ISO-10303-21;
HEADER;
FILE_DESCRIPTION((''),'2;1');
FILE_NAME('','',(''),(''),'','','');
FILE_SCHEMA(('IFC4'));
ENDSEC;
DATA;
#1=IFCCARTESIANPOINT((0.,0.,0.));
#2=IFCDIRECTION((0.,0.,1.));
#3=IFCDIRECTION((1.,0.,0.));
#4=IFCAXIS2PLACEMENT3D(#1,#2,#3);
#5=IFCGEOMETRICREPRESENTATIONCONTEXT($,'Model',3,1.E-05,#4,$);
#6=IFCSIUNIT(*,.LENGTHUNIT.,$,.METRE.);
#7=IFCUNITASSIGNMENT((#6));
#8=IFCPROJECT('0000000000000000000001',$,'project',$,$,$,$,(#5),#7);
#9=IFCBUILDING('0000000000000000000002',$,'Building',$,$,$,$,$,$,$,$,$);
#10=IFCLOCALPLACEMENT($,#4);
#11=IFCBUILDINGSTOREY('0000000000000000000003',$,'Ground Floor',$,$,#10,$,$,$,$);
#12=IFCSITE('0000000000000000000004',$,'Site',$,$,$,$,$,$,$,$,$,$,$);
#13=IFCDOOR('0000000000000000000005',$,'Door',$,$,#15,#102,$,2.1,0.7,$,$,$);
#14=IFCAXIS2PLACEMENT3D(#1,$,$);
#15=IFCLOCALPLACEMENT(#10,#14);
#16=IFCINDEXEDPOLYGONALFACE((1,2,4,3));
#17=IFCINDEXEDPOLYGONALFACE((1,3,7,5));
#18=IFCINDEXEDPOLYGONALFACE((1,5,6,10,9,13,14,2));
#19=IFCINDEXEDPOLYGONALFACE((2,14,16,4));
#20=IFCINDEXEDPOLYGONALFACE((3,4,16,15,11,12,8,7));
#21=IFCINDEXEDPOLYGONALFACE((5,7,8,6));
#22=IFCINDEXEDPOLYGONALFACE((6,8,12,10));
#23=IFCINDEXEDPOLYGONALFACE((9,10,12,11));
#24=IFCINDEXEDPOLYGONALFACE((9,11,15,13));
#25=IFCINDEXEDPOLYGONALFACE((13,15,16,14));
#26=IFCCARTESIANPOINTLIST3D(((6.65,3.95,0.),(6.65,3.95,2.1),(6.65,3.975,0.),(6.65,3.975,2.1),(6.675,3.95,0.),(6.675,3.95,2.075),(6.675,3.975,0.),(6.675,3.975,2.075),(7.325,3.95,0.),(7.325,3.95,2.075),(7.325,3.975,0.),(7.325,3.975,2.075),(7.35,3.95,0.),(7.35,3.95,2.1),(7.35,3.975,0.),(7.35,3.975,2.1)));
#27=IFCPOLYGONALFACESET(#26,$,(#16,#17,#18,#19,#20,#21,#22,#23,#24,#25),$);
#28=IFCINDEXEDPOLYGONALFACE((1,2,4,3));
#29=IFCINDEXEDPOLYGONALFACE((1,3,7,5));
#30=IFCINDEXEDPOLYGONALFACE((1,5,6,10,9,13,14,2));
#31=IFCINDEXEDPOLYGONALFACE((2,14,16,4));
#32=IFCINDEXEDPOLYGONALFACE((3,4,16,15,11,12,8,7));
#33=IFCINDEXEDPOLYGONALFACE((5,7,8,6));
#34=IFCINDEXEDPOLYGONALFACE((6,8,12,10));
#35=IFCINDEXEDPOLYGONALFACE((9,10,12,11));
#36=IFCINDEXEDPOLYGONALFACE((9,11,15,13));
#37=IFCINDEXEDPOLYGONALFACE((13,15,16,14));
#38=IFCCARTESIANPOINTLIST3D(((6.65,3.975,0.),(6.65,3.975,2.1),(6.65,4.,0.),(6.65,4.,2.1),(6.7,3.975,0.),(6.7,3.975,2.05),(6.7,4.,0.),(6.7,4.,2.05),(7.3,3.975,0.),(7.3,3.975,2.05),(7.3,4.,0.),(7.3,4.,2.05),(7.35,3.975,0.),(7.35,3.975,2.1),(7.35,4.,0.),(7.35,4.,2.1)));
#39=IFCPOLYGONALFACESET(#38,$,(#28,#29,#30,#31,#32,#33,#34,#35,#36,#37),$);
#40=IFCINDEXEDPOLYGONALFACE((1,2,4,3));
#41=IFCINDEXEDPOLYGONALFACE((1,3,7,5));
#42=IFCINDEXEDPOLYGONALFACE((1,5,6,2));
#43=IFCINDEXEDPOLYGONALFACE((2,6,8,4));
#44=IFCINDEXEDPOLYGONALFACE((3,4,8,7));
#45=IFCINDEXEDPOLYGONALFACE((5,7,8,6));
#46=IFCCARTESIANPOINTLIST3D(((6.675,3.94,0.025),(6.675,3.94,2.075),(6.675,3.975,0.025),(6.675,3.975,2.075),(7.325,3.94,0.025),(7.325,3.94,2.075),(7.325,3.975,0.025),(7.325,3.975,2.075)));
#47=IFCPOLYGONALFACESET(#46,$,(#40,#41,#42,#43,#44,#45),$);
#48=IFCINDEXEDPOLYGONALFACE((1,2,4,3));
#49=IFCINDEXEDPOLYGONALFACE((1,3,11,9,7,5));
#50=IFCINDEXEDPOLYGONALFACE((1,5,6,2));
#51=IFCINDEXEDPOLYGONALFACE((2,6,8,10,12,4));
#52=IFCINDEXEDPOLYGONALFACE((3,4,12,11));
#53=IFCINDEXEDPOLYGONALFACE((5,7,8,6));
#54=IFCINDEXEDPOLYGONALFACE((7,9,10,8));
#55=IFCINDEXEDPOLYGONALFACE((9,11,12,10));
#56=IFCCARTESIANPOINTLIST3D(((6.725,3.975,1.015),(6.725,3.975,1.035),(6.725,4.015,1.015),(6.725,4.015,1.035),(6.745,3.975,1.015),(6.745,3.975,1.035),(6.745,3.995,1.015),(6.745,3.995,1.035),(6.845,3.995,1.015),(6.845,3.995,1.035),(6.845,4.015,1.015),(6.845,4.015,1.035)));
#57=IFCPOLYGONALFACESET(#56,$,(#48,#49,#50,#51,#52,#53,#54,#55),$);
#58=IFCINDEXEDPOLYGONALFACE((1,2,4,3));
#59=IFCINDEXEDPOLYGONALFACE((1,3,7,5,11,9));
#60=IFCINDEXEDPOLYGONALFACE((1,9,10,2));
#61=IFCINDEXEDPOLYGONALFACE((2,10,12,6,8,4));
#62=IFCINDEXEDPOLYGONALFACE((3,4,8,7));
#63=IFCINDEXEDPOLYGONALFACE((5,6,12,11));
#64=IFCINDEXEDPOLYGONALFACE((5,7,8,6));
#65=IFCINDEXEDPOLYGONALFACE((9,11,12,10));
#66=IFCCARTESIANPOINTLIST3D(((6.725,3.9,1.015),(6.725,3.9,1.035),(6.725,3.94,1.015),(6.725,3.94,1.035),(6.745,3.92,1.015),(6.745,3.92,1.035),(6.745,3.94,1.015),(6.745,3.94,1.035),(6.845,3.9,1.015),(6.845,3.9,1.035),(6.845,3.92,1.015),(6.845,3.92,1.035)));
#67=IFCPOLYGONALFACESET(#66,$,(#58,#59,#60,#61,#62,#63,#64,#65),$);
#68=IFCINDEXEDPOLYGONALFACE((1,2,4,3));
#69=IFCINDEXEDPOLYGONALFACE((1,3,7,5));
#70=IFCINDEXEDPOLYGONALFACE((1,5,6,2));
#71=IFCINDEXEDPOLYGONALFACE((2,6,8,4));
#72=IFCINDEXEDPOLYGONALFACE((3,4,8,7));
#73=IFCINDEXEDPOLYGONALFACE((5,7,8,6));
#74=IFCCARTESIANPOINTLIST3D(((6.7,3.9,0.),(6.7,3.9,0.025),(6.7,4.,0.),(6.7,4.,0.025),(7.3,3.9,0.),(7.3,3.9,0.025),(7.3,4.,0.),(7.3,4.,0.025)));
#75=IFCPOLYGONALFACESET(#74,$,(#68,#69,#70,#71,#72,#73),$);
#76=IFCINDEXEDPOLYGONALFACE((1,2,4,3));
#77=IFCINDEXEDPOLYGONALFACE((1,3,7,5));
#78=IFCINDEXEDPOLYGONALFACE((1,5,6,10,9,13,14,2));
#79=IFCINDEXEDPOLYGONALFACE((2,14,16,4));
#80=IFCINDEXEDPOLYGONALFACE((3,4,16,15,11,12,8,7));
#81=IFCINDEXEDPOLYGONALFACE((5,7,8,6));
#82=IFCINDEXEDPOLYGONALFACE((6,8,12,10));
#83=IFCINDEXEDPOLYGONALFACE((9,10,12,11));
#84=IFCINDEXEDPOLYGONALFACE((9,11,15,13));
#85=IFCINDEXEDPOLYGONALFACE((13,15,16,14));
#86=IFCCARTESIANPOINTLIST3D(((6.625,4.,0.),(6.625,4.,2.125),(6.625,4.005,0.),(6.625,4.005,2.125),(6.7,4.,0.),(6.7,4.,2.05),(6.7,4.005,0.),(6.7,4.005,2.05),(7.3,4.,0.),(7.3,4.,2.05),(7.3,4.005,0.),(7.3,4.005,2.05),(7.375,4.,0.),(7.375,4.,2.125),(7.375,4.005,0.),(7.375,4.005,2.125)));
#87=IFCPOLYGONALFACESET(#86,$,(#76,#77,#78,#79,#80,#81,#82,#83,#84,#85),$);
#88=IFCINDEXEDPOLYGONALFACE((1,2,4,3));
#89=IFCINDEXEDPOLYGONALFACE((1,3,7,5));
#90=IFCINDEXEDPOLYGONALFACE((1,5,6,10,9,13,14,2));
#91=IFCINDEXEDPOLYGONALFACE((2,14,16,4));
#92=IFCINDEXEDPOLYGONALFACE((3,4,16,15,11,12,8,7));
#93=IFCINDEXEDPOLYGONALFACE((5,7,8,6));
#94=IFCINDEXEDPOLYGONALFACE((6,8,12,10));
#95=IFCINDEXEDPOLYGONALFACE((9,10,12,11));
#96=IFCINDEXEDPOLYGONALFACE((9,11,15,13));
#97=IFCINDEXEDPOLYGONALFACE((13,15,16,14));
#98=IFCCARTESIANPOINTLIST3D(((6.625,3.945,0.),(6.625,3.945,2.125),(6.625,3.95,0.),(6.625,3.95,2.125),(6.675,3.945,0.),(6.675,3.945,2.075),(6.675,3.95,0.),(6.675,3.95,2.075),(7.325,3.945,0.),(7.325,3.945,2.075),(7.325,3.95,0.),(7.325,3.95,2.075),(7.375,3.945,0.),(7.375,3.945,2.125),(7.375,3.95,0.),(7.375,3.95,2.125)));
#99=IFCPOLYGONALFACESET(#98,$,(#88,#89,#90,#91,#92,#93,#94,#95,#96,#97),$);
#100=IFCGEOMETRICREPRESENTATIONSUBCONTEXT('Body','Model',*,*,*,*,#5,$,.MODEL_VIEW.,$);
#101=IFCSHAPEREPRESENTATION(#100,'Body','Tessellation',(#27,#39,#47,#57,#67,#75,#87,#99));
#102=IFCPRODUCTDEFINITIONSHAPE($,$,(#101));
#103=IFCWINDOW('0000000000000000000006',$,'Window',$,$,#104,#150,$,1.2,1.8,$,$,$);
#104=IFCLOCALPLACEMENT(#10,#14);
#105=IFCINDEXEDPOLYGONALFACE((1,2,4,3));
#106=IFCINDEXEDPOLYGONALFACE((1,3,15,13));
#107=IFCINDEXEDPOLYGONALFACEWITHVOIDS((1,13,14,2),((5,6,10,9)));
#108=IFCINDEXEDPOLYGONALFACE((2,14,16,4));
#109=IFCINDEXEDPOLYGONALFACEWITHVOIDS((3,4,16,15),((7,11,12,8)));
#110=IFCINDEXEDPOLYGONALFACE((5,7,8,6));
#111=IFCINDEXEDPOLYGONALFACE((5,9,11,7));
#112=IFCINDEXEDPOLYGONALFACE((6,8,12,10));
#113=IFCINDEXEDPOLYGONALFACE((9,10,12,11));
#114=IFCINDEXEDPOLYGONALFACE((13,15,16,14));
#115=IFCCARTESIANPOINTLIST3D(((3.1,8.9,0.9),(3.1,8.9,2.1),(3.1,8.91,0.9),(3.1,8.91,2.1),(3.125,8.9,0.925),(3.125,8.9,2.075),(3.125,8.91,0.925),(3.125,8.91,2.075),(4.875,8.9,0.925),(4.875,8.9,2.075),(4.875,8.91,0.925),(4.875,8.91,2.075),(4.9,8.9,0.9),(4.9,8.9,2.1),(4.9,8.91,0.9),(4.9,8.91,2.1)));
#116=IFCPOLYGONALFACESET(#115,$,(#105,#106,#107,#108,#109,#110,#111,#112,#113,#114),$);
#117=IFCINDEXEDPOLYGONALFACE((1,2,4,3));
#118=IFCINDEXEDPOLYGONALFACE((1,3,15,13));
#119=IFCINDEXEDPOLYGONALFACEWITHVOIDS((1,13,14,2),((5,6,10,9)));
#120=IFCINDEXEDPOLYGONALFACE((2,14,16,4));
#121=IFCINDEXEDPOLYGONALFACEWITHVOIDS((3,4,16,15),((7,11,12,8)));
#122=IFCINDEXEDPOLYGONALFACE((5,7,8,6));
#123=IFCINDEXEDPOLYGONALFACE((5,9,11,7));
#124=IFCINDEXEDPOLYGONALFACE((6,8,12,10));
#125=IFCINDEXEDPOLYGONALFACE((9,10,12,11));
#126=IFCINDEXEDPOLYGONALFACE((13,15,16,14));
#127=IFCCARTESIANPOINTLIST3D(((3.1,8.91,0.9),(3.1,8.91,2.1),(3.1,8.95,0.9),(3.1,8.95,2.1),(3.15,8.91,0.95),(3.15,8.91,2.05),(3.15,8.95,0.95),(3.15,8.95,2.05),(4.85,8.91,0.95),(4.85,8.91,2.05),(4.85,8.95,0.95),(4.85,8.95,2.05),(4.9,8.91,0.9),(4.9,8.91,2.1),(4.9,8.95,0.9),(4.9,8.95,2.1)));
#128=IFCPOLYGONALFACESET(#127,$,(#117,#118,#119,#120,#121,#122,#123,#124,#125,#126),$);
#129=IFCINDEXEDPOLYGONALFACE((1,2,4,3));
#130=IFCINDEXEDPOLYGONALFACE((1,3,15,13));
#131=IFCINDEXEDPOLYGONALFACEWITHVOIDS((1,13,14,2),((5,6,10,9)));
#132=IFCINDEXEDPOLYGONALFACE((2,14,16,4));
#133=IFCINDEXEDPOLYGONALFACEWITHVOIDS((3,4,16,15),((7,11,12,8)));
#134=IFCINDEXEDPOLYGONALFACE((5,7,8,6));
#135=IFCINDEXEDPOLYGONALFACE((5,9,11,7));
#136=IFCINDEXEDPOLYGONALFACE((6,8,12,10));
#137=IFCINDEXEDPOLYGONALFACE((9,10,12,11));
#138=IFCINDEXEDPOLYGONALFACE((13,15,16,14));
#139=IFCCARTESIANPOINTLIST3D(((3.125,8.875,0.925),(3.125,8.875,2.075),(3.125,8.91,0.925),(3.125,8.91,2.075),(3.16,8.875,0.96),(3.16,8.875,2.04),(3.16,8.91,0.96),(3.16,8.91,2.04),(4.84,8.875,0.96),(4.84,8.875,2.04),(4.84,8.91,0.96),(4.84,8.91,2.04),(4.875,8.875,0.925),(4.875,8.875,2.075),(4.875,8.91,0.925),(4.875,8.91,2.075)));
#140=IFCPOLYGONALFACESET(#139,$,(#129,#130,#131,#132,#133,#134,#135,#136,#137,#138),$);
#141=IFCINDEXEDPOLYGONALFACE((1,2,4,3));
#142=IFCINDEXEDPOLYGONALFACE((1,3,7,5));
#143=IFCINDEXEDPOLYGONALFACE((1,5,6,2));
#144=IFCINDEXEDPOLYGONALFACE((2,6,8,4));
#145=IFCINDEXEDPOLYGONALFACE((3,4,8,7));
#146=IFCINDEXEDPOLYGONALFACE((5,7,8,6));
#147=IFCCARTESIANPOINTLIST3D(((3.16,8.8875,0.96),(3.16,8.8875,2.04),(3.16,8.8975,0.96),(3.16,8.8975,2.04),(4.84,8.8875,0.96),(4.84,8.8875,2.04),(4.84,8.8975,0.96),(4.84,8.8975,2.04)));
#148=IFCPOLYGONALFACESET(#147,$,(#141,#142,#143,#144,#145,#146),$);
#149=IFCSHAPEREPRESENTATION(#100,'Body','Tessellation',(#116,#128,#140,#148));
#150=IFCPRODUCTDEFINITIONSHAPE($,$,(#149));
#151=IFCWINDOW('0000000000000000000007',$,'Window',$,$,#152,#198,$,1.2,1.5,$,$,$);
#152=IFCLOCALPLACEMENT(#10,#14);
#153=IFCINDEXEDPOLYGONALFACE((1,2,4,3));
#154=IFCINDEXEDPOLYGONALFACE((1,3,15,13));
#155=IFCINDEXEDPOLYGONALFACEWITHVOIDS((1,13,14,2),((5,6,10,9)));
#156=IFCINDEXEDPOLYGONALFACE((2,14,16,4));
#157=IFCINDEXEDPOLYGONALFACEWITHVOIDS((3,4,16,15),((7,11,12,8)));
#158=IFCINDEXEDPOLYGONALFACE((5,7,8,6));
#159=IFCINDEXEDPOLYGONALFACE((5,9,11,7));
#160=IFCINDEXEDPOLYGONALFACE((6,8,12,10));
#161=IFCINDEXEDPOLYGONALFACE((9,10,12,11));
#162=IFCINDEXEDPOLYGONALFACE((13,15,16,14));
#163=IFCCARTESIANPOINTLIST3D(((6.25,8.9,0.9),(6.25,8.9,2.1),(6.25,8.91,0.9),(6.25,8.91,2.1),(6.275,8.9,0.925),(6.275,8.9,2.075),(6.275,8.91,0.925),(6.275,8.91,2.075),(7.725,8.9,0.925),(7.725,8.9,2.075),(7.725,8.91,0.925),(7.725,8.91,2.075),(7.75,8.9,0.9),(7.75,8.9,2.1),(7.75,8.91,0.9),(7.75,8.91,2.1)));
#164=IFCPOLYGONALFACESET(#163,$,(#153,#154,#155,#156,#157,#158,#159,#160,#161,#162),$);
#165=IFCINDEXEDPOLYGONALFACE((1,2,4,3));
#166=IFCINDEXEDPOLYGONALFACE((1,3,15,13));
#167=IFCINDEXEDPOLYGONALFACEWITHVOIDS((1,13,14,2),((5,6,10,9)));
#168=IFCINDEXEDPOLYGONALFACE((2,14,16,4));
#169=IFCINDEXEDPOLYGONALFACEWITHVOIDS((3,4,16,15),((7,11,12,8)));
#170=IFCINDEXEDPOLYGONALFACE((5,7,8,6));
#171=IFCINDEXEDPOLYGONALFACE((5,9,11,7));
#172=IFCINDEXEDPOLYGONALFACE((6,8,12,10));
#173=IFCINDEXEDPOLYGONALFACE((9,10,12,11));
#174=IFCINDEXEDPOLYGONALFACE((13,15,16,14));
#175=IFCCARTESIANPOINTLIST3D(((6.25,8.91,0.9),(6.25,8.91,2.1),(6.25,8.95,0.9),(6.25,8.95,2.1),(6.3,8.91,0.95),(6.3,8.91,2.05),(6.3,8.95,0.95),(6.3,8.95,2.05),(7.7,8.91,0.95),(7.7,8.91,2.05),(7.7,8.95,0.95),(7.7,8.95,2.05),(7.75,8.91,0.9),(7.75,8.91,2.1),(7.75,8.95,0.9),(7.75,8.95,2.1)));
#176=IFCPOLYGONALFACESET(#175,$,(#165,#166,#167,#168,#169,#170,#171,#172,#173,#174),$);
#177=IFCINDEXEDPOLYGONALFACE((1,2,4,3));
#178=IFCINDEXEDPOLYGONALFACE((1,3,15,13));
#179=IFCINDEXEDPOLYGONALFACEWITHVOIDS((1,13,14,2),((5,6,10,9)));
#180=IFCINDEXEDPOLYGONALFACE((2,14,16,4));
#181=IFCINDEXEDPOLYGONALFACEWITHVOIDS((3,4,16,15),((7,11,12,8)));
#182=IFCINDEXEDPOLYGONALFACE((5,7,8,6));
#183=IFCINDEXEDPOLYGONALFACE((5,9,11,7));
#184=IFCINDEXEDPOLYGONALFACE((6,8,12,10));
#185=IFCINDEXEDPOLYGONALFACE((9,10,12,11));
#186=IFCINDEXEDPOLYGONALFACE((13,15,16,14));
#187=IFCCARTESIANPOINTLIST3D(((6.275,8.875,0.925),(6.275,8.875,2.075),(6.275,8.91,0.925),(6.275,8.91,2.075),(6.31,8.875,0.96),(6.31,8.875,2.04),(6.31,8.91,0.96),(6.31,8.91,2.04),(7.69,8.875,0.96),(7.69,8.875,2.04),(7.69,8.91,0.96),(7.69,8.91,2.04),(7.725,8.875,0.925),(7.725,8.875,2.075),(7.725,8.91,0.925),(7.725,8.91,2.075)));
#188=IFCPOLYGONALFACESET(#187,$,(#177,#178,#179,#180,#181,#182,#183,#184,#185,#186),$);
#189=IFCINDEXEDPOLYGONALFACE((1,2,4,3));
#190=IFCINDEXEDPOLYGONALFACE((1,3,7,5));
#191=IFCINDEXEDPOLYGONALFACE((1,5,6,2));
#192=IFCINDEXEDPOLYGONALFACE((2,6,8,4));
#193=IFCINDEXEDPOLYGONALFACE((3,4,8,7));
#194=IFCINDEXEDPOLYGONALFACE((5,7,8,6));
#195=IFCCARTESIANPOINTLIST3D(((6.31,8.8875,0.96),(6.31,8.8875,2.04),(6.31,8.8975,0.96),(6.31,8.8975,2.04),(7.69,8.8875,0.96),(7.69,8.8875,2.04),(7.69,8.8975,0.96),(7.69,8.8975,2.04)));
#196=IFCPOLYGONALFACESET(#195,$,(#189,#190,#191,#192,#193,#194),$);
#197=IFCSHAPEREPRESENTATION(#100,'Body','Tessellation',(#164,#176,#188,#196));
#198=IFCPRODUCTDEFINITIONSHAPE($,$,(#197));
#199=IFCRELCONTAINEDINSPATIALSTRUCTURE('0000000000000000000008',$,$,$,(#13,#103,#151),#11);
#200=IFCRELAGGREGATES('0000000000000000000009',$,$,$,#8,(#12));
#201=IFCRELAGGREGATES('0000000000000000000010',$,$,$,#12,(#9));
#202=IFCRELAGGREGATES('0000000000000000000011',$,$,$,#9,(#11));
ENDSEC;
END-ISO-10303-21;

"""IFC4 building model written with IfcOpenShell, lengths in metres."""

from ifc_helpers import new_model, si_unit, frame, origin_with_axes, place, context, subcontext, project, spatial, line, indexed_curve, outline, extrude, element, save


model = new_model("IFC4")

# Units and contexts
model_context = context("Model", 3, precision=1e-05, world=origin_with_axes())
body_context = subcontext(model_context, "Body", "Model", "MODEL_VIEW")
ifc_project = project(units=[si_unit("LENGTHUNIT", "METRE")], contexts=[model_context])

# Site, building, storey
site = spatial("IfcSite", under=ifc_project, Name="Site")
building = spatial("IfcBuilding", under=site, Name="Building")
storey_placement = place(None, origin_with_axes())
storey = spatial("IfcBuildingStorey", under=building, at=storey_placement, Name="Ground Floor")

# Door
door_1_placement = place(storey_placement, frame((7.35, 4.0, 0.0), z_axis=(0.0, 0.0, 1.0), x_axis=(-1.0, 0.0, 0.0)))
element("IfcDoor", 1, at=door_1_placement, inside=storey, Name="Door", OverallHeight=2.1, OverallWidth=0.7, context=body_context, shape_type="SweptSolid", body=[
    extrude(outline(indexed_curve([(0.0, 0.0), (0.0, 2.1), (0.7, 2.1), (0.7, 0.0), (0.675, 0.0), (0.675, 2.075), (0.025, 2.075), (0.025, 0.0)], segments=[line(1, 2, 3, 4, 5, 6, 7, 8, 1)])), frame((0.0, 0.025, 0.0), z_axis=(0.0, -1.0, 0.0), x_axis=(1.0, 0.0, 0.0)), (0.0, 0.0, -1.0), 0.025),
    extrude(outline(indexed_curve([(0.0, 0.0), (0.0, 2.1), (0.7, 2.1), (0.7, 0.0), (0.65, 0.0), (0.65, 2.05), (0.05, 2.05), (0.05, 0.0)], segments=[line(1, 2, 3, 4, 5, 6, 7, 8, 1)])), frame((0.0, 0.0, 0.0), z_axis=(0.0, -1.0, 0.0), x_axis=(1.0, 0.0, 0.0)), (0.0, 0.0, -1.0), 0.025),
    extrude(outline(indexed_curve([(0.0, 0.0), (0.65, 0.0), (0.65, 0.035), (0.0, 0.035)], segments=[line(1, 2, 3, 4, 1)])), frame((0.025, 0.025, 0.025), z_axis=(0.0, 0.0, 1.0), x_axis=(1.0, 0.0, 0.0)), (0.0, 0.0, 1.0), 2.05),
    extrude(outline(indexed_curve([(0.0, 0.0), (0.0, -0.04), (-0.12, -0.04), (-0.12, -0.02), (-0.02, -0.02), (-0.02, 0.0)], segments=[line(1, 2, 3, 4, 5, 6, 1)])), frame((0.625, 0.025, 1.015), z_axis=(0.0, 0.0, 1.0), x_axis=(1.0, 0.0, 0.0)), (0.0, 0.0, 1.0), 0.02),
    extrude(outline(indexed_curve([(0.0, 0.0), (0.0, 0.04), (-0.12, 0.04), (-0.12, 0.02), (-0.02, 0.02), (-0.02, 0.0)], segments=[line(1, 2, 3, 4, 5, 6, 1)])), frame((0.625, 0.06, 1.015), z_axis=(0.0, 0.0, 1.0), x_axis=(1.0, 0.0, 0.0)), (0.0, 0.0, 1.0), 0.02),
    extrude(outline(indexed_curve([(0.0, 0.0), (0.6, 0.0), (0.6, 0.1), (0.0, 0.1)], segments=[line(1, 2, 3, 4, 1)])), frame((0.05, 0.0, 0.0), z_axis=(0.0, 0.0, 1.0), x_axis=(1.0, 0.0, 0.0)), (0.0, 0.0, 1.0), 0.025),
    extrude(outline(indexed_curve([(0.0, 0.0), (0.0, 2.125), (0.75, 2.125), (0.75, 0.0), (0.675, 0.0), (0.675, 2.05), (0.075, 2.05), (0.075, 0.0)], segments=[line(1, 2, 3, 4, 5, 6, 7, 8, 1)])), frame((-0.025, -0.005, 0.0), z_axis=(0.0, -1.0, 0.0), x_axis=(1.0, 0.0, 0.0)), (0.0, 0.0, -1.0), 0.005),
    extrude(outline(indexed_curve([(0.0, 0.0), (0.0, 2.125), (0.75, 2.125), (0.75, 0.0), (0.7, 0.0), (0.7, 2.075), (0.05, 2.075), (0.05, 0.0)], segments=[line(1, 2, 3, 4, 5, 6, 7, 8, 1)])), frame((-0.025, 0.05, 0.0), z_axis=(0.0, -1.0, 0.0), x_axis=(1.0, 0.0, 0.0)), (0.0, 0.0, -1.0), 0.005),
])

# Windows
window_1_placement = place(storey_placement, frame((4.9, 9.0, 0.9), z_axis=(0.0, 0.0, 1.0), x_axis=(-1.0, 0.0, 0.0)))
element("IfcWindow", 2, at=window_1_placement, inside=storey, Name="Window", OverallHeight=1.2, OverallWidth=1.8, context=body_context, shape_type="SweptSolid", body=[
    extrude(outline(indexed_curve([(0.0, 0.0), (1.8, 0.0), (1.8, 1.2), (0.0, 1.2)], segments=[line(1, 2, 3, 4, 1)]), holes=[indexed_curve([(0.025, 0.025), (1.775, 0.025), (1.775, 1.175), (0.025, 1.175)], segments=[line(1, 2, 3, 4, 1)])]), frame((0.0, 0.09, 0.0), z_axis=(0.0, -1.0, 0.0), x_axis=(1.0, 0.0, 0.0)), (0.0, 0.0, -1.0), 0.01),
    extrude(outline(indexed_curve([(0.0, 0.0), (1.8, 0.0), (1.8, 1.2), (0.0, 1.2)], segments=[line(1, 2, 3, 4, 1)]), holes=[indexed_curve([(0.05, 0.05), (1.75, 0.05), (1.75, 1.15), (0.05, 1.15)], segments=[line(1, 2, 3, 4, 1)])]), frame((0.0, 0.05, 0.0), z_axis=(0.0, -1.0, 0.0), x_axis=(1.0, 0.0, 0.0)), (0.0, 0.0, -1.0), 0.04),
    extrude(outline(indexed_curve([(0.0, 0.0), (1.75, 0.0), (1.75, 1.15), (0.0, 1.15)], segments=[line(1, 2, 3, 4, 1)]), holes=[indexed_curve([(0.035, 0.035), (1.715, 0.035), (1.715, 1.115), (0.035, 1.115)], segments=[line(1, 2, 3, 4, 1)])]), frame((0.025, 0.09, 0.025), z_axis=(0.0, -1.0, 0.0), x_axis=(1.0, 0.0, 0.0)), (0.0, 0.0, -1.0), 0.035),
    extrude(outline(indexed_curve([(0.035, 0.035), (1.715, 0.035), (1.715, 1.115), (0.035, 1.115)], segments=[line(1, 2, 3, 4, 1)])), frame((0.025, 0.1025, 0.025), z_axis=(0.0, -1.0, 0.0), x_axis=(1.0, 0.0, 0.0)), (0.0, 0.0, -1.0), 0.01),
])
window_2_placement = place(storey_placement, frame((7.75, 9.0, 0.9), z_axis=(0.0, 0.0, 1.0), x_axis=(-1.0, 0.0, 0.0)))
element("IfcWindow", 3, at=window_2_placement, inside=storey, Name="Window", OverallHeight=1.2, OverallWidth=1.5, context=body_context, shape_type="SweptSolid", body=[
    extrude(outline(indexed_curve([(0.0, 0.0), (1.5, 0.0), (1.5, 1.2), (0.0, 1.2)], segments=[line(1, 2, 3, 4, 1)]), holes=[indexed_curve([(0.025, 0.025), (1.475, 0.025), (1.475, 1.175), (0.025, 1.175)], segments=[line(1, 2, 3, 4, 1)])]), frame((0.0, 0.09, 0.0), z_axis=(0.0, -1.0, 0.0), x_axis=(1.0, 0.0, 0.0)), (0.0, 0.0, -1.0), 0.01),
    extrude(outline(indexed_curve([(0.0, 0.0), (1.5, 0.0), (1.5, 1.2), (0.0, 1.2)], segments=[line(1, 2, 3, 4, 1)]), holes=[indexed_curve([(0.05, 0.05), (1.45, 0.05), (1.45, 1.15), (0.05, 1.15)], segments=[line(1, 2, 3, 4, 1)])]), frame((0.0, 0.05, 0.0), z_axis=(0.0, -1.0, 0.0), x_axis=(1.0, 0.0, 0.0)), (0.0, 0.0, -1.0), 0.04),
    extrude(outline(indexed_curve([(0.0, 0.0), (1.45, 0.0), (1.45, 1.15), (0.0, 1.15)], segments=[line(1, 2, 3, 4, 1)]), holes=[indexed_curve([(0.035, 0.035), (1.415, 0.035), (1.415, 1.115), (0.035, 1.115)], segments=[line(1, 2, 3, 4, 1)])]), frame((0.025, 0.09, 0.025), z_axis=(0.0, -1.0, 0.0), x_axis=(1.0, 0.0, 0.0)), (0.0, 0.0, -1.0), 0.035),
    extrude(outline(indexed_curve([(0.035, 0.035), (1.415, 0.035), (1.415, 1.115), (0.035, 1.115)], segments=[line(1, 2, 3, 4, 1)])), frame((0.025, 0.1025, 0.025), z_axis=(0.0, -1.0, 0.0), x_axis=(1.0, 0.0, 0.0)), (0.0, 0.0, -1.0), 0.01),
])

save(model, "model.ifc")
